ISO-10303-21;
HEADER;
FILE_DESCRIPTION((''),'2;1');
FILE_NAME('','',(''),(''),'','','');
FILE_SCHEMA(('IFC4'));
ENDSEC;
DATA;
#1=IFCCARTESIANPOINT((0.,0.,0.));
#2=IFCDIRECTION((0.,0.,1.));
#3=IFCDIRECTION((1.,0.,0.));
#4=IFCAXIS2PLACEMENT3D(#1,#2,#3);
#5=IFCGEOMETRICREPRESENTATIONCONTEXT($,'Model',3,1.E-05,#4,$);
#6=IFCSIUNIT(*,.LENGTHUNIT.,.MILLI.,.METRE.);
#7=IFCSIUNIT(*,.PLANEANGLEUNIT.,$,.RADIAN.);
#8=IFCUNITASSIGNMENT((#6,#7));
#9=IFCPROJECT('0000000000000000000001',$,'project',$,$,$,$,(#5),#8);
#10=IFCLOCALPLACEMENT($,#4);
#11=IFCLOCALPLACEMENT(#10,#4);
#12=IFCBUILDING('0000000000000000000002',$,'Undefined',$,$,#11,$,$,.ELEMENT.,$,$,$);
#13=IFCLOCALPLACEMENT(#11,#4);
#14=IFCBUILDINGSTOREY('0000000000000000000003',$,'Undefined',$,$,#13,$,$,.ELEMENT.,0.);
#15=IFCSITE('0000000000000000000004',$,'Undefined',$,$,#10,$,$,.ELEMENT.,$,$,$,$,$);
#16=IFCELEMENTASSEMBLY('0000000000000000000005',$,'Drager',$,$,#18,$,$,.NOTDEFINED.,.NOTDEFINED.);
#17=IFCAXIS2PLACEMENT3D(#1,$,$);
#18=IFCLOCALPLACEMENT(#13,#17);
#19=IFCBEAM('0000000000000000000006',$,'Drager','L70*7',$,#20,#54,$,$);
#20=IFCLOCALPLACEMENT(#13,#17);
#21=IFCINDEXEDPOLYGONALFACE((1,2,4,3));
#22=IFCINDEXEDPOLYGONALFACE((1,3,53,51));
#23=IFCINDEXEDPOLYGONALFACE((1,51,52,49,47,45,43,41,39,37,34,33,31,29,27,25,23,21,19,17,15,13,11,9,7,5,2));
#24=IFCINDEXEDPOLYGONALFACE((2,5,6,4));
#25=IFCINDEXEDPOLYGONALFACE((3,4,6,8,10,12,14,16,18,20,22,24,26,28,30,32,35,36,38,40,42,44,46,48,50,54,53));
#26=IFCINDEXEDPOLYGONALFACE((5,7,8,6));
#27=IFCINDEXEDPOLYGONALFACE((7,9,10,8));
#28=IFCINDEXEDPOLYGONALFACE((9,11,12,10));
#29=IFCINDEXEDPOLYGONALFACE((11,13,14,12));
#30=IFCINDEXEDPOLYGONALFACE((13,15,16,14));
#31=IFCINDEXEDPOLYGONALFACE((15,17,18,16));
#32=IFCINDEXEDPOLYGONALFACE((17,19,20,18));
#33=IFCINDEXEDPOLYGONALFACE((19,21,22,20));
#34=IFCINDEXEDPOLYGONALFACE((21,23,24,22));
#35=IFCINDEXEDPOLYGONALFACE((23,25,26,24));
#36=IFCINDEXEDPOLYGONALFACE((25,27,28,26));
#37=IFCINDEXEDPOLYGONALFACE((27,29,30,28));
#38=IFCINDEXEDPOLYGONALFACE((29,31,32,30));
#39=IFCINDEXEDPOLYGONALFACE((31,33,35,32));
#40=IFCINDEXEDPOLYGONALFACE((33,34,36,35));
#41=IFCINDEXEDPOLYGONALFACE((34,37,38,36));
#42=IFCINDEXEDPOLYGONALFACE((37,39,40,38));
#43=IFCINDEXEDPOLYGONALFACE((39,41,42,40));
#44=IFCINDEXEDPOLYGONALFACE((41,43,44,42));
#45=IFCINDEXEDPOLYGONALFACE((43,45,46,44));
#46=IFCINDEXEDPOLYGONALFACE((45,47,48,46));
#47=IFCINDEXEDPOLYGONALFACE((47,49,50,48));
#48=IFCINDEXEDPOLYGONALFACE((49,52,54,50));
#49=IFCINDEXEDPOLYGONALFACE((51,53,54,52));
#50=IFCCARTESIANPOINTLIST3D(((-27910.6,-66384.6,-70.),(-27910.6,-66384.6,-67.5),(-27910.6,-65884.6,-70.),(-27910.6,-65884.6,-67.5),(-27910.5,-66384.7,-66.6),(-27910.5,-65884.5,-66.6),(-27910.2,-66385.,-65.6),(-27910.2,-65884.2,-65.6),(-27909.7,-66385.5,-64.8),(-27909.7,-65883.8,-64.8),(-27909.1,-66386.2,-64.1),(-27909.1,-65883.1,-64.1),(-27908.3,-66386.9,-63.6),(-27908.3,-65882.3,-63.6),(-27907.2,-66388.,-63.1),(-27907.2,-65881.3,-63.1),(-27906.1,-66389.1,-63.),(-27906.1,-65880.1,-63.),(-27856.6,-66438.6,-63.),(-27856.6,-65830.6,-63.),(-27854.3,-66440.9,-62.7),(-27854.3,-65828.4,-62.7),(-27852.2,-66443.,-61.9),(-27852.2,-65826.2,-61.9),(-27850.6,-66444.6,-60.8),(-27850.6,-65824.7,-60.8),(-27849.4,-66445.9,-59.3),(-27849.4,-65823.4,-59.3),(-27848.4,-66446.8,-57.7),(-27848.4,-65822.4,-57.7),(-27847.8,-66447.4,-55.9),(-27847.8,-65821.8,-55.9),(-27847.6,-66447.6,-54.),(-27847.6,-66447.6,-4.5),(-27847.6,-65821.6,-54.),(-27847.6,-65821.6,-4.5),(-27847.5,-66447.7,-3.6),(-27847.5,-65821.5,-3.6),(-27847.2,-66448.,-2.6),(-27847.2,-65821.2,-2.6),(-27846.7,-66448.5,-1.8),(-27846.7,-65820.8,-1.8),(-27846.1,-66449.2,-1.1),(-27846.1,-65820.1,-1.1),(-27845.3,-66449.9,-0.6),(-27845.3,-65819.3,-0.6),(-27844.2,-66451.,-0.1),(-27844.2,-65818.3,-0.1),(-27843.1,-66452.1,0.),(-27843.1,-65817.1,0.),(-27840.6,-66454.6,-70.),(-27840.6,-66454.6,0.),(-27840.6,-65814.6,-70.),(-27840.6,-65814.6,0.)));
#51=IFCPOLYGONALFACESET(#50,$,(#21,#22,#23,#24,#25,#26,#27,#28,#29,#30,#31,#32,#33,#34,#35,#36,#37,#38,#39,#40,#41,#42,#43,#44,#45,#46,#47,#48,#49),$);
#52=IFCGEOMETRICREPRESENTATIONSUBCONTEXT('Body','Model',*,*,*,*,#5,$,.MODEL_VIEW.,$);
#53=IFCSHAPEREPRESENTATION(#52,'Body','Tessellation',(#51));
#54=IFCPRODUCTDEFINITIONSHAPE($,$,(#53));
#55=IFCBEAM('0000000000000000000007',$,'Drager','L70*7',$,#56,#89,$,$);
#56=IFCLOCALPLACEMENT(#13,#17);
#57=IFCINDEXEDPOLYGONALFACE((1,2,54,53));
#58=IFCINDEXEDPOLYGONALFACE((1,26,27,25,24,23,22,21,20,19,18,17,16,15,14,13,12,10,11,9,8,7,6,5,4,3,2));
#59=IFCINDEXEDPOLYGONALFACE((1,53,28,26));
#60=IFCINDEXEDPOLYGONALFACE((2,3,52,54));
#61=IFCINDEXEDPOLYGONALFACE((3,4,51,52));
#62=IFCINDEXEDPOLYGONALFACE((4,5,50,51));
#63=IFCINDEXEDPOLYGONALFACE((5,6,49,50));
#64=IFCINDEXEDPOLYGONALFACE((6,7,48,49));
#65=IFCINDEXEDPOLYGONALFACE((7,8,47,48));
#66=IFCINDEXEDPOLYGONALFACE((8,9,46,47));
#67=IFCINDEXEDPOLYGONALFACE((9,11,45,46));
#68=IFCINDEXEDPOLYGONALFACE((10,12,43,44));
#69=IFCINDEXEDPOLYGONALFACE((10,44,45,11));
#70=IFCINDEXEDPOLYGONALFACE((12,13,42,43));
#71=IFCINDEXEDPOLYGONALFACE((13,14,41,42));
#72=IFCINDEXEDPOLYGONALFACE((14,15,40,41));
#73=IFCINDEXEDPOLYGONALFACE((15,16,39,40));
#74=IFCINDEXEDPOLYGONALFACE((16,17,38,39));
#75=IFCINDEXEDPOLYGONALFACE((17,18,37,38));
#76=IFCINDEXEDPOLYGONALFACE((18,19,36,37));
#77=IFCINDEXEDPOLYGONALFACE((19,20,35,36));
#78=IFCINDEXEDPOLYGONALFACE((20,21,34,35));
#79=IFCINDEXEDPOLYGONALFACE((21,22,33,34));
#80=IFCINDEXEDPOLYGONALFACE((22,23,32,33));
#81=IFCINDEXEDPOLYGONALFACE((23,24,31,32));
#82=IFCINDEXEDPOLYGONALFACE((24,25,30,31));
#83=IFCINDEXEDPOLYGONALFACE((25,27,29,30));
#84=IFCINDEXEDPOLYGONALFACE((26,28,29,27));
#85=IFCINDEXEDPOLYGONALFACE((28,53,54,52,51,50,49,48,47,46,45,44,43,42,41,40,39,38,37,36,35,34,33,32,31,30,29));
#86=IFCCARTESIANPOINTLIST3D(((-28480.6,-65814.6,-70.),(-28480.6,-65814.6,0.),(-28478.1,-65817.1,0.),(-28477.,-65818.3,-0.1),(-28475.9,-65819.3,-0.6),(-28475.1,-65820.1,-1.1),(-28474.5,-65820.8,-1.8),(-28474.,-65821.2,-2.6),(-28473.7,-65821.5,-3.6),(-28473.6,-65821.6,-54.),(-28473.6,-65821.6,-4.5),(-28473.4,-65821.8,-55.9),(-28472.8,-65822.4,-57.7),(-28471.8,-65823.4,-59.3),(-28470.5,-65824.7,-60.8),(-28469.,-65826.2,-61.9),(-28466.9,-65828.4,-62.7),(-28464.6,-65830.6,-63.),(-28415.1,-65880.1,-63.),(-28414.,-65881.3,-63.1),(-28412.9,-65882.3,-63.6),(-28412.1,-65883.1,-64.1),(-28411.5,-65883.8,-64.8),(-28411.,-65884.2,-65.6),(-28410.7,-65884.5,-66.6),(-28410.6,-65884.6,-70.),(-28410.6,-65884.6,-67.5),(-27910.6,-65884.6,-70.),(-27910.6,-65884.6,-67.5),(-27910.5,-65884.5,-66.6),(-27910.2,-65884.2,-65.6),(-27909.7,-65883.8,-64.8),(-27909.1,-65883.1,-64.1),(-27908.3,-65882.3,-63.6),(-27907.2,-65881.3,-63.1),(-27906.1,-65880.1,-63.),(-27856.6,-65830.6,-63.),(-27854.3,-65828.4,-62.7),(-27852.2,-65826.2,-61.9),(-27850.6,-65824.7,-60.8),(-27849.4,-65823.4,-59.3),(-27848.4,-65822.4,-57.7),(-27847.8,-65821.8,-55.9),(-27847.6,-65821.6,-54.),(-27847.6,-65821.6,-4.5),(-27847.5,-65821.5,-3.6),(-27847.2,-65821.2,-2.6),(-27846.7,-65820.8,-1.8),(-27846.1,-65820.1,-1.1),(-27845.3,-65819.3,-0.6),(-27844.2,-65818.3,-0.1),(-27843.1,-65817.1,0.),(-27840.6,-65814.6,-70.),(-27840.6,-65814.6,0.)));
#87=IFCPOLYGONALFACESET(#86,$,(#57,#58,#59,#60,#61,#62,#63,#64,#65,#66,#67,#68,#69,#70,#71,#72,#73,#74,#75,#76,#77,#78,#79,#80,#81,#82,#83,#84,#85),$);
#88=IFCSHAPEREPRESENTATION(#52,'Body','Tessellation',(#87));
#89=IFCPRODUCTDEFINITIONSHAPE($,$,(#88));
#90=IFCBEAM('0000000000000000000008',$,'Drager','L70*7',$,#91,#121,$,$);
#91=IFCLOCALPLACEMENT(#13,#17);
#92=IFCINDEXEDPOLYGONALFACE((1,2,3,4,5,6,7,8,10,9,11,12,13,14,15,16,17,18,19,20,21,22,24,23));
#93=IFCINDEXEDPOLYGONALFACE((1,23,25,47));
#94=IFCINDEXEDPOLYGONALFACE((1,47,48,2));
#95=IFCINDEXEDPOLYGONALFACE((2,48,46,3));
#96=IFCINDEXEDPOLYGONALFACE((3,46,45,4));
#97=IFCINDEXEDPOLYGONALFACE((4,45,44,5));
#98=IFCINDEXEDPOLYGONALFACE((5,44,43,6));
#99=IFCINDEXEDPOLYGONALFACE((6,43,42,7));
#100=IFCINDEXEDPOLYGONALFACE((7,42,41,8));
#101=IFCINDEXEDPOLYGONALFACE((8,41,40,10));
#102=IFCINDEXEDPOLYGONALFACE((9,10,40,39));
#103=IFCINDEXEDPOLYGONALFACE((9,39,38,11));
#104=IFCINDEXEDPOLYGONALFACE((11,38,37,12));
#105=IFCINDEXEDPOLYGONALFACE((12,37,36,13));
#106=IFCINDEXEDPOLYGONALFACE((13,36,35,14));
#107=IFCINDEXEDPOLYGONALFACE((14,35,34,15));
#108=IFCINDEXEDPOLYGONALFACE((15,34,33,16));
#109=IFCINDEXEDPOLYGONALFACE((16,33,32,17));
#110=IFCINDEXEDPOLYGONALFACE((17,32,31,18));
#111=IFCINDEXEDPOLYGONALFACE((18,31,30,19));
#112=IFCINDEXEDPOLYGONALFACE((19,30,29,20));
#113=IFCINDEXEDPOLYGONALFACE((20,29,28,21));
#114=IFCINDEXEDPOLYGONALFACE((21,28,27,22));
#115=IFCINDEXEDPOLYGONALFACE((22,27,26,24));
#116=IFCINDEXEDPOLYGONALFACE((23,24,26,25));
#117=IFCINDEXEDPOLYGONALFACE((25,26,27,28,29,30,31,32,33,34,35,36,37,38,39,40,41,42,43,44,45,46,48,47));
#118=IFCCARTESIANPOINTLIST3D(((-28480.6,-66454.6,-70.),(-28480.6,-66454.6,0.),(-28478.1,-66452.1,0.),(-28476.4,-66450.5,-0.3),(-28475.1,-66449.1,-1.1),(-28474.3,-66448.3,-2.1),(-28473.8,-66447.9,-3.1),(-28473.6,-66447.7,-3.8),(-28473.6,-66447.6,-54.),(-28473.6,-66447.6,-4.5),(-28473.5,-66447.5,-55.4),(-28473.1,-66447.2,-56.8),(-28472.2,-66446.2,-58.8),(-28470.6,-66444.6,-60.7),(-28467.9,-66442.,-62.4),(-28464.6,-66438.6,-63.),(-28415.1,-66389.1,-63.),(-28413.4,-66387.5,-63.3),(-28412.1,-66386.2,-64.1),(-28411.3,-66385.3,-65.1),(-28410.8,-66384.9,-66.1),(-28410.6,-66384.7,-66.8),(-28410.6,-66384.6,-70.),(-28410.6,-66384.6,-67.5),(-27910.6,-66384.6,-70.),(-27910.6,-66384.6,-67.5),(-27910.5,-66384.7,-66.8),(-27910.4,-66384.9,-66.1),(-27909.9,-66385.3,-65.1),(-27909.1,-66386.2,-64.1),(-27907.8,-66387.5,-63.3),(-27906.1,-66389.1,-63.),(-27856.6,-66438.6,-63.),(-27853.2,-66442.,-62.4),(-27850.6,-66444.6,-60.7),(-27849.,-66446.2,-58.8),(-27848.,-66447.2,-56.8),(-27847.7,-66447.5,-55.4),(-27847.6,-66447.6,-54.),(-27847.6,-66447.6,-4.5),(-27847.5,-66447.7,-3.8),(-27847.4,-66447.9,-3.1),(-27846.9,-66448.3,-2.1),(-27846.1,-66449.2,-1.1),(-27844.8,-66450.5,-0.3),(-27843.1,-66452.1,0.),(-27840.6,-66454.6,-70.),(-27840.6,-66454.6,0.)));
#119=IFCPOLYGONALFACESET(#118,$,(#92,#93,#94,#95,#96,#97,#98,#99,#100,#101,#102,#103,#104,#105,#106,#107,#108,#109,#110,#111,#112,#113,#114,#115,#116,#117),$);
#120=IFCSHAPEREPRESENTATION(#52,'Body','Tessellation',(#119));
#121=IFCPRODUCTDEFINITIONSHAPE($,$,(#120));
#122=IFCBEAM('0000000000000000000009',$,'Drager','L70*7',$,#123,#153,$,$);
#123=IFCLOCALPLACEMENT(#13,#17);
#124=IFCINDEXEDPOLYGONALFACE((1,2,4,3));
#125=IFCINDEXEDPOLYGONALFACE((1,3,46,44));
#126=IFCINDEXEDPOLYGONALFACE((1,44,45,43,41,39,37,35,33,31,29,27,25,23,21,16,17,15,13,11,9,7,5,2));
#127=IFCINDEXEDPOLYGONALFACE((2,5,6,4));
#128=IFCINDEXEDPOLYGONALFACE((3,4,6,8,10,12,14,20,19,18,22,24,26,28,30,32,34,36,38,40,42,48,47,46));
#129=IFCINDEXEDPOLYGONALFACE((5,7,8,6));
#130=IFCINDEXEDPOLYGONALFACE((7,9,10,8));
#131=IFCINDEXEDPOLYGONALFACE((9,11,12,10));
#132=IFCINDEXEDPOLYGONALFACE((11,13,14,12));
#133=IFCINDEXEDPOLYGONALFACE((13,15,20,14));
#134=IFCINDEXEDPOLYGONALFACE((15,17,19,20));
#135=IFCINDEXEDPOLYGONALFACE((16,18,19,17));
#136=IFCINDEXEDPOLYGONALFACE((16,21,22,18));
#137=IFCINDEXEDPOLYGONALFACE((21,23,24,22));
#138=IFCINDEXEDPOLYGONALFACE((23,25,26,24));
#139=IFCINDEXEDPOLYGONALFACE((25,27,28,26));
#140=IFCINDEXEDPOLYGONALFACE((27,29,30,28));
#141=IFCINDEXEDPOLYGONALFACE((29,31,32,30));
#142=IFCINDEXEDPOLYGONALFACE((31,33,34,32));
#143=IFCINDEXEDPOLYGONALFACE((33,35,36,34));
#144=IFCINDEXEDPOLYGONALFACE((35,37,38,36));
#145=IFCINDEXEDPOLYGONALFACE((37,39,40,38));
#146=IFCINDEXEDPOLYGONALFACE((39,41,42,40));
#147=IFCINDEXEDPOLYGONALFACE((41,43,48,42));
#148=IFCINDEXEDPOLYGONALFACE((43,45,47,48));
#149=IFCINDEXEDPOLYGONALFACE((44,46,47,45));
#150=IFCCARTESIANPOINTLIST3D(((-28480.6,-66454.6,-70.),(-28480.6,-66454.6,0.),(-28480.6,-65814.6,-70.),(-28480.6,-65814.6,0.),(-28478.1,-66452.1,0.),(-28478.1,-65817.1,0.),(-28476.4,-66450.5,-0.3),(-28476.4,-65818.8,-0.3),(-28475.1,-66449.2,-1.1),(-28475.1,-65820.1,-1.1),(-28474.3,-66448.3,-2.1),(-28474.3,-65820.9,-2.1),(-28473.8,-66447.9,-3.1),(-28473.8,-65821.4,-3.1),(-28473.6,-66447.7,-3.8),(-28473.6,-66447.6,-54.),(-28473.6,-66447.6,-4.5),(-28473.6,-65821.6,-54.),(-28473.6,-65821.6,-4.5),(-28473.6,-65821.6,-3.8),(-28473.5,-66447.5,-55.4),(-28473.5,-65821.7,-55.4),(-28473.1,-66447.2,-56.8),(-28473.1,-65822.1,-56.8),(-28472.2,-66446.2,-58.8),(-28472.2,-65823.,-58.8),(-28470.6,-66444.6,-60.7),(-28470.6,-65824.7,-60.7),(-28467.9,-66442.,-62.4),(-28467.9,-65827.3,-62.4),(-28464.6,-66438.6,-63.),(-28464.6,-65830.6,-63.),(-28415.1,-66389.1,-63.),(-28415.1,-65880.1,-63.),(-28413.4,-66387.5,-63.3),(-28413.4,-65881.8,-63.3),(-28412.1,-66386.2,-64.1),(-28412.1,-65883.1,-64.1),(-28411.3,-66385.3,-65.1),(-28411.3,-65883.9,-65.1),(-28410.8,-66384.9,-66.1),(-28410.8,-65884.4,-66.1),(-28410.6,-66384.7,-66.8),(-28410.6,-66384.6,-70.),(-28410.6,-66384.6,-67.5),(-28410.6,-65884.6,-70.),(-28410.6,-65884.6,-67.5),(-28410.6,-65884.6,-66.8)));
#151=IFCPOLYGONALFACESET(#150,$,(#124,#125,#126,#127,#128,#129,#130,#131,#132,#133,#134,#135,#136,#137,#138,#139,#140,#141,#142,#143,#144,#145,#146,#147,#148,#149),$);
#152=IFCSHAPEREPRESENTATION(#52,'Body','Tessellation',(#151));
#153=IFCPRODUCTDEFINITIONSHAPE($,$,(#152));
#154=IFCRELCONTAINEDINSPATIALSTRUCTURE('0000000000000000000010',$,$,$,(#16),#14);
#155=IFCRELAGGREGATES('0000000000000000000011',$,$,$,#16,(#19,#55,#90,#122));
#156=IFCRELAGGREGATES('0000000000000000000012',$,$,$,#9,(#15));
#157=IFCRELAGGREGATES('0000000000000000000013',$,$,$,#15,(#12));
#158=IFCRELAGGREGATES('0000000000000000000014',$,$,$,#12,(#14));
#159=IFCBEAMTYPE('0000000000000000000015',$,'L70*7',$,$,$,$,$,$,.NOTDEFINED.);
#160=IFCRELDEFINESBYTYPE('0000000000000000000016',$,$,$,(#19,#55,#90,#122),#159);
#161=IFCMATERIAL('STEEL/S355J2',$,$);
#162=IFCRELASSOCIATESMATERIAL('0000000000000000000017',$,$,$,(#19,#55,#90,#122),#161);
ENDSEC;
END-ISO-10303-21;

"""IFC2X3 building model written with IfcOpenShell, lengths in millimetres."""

from ifc_helpers import new_model, si_unit, frame, origin_with_axes, origin_2d_with_axis, place, context, subcontext, project, spatial, l_section, extrude, clip, halfspace, material, type_object, element, aggregate, save


model = new_model("IFC2X3")

# Units and contexts
model_context = context("Model", 3, precision=1e-05, world=origin_with_axes())
body_context = subcontext(model_context, "Body", "Model", "MODEL_VIEW")
ifc_project = project(units=[si_unit("LENGTHUNIT", "METRE", prefix="MILLI"), si_unit("PLANEANGLEUNIT", "RADIAN")], contexts=[model_context])

# Site, building, storey
site_placement = place(None, origin_with_axes())
site = spatial("IfcSite", under=ifc_project, at=site_placement, Name="Undefined", CompositionType="ELEMENT")
building_placement = place(site_placement, origin_with_axes())
building = spatial("IfcBuilding", under=site, at=building_placement, Name="Undefined", CompositionType="ELEMENT")
storey_placement = place(building_placement, origin_with_axes())
storey = spatial("IfcBuildingStorey", under=building, at=storey_placement, Name="Undefined", CompositionType="ELEMENT", Elevation=0.0)

# Shared definitions
ifc_material_1 = material(Name="STEEL/S355J2")
beam_type_1 = type_object("IfcBeamType", Name="L70*7", PredefinedType="NOTDEFINED")

# Element assembly, beams
assembly_1_placement = place(storey_placement, origin_with_axes())
assembly_1 = element("IfcElementAssembly", 1, at=assembly_1_placement, inside=storey, Name="Drager", AssemblyPlace="NOTDEFINED", PredefinedType="NOTDEFINED")
beam_1_placement = place(assembly_1_placement, frame((-27875.6, -65884.6, -35.0), z_axis=(0.0, 0.0, 1.0), x_axis=(0.000002, -1.0, 0.0)))
beam_1 = element("IfcBeam", 2, at=beam_1_placement, type_object=beam_type_1, material=ifc_material_1, Name="Drager", Description="L70*7", context=body_context, shape_type="Clipping", body=[
    clip(clip(extrude(l_section(Depth=70.0, Width=70.0, Thickness=7.0, FilletRadius=9.0, EdgeRadius=4.5, at=origin_2d_with_axis()), frame((605.7, 0.0, 0.0), z_axis=(-1.0, 0.0, 0.0), x_axis=(0.0, -1.0, 0.0)), (0.0, 0.0, 1.0), 711.4), halfspace(frame((500.0, -35.0, 35.0), z_axis=(-0.707107, 0.707107, 0.0), x_axis=(0.707107, 0.707107, 0.0)), True)), halfspace(frame((0.0, -35.0, 35.0), z_axis=(-0.707107, -0.707107, 0.0), x_axis=(-0.707107, 0.707107, 0.0)), False)),
])
beam_2_placement = place(assembly_1_placement, frame((-28410.6, -65849.6, -35.0), z_axis=(0.0, 0.0, 1.0), x_axis=(1.0, 0.000003, 0.0)))
beam_2 = element("IfcBeam", 3, at=beam_2_placement, type_object=beam_type_1, material=ifc_material_1, Name="Drager", Description="L70*7", context=body_context, shape_type="Clipping", body=[
    clip(clip(extrude(l_section(Depth=70.0, Width=70.0, Thickness=7.0, FilletRadius=9.0, EdgeRadius=4.5, at=origin_2d_with_axis()), frame((605.7, 0.0, 0.0), z_axis=(-1.0, 0.0, 0.0), x_axis=(0.0, -1.0, 0.0)), (0.0, 0.0, 1.0), 711.4), halfspace(frame((500.0, -35.0, 35.0), z_axis=(-0.707107, 0.707107, 0.0), x_axis=(0.707107, 0.707107, 0.0)), True)), halfspace(frame((0.0, -35.0, 35.0), z_axis=(-0.707107, -0.707107, 0.0), x_axis=(-0.707107, 0.707107, 0.0)), False)),
])
beam_3_placement = place(assembly_1_placement, frame((-27910.6, -66419.6, -35.0), z_axis=(0.0, 0.0, 1.0), x_axis=(-1.0, 0.0, 0.0)))
beam_3 = element("IfcBeam", 4, at=beam_3_placement, type_object=beam_type_1, material=ifc_material_1, Name="Drager", Description="L70*7", context=body_context, shape_type="Clipping", body=[
    clip(clip(extrude(l_section(Depth=70.0, Width=70.0, Thickness=7.0, FilletRadius=9.0, EdgeRadius=4.5, at=origin_2d_with_axis()), frame((605.7, 0.0, 0.0), z_axis=(-1.0, 0.0, 0.0), x_axis=(0.0, -1.0, 0.0)), (0.0, 0.0, 1.0), 711.4), halfspace(frame((500.0, -35.0, 35.0), z_axis=(0.707107, -0.707107, 0.0), x_axis=(0.0, 0.0, 1.0)), False)), halfspace(frame((0.0, -35.0, 35.0), z_axis=(0.707107, 0.707107, 0.0), x_axis=(0.0, 0.0, 1.0)), True)),
])
beam_4_placement = place(assembly_1_placement, frame((-28445.6, -66384.6, -35.0), z_axis=(0.0, 0.0, 1.0), x_axis=(0.0, 1.0, 0.0)))
beam_4 = element("IfcBeam", 5, at=beam_4_placement, type_object=beam_type_1, material=ifc_material_1, Name="Drager", Description="L70*7", context=body_context, shape_type="Clipping", body=[
    clip(clip(extrude(l_section(Depth=70.0, Width=70.0, Thickness=7.0, FilletRadius=9.0, EdgeRadius=4.5, at=origin_2d_with_axis()), frame((605.7, 0.0, 0.0), z_axis=(-1.0, 0.0, 0.0), x_axis=(0.0, -1.0, 0.0)), (0.0, 0.0, 1.0), 711.4), halfspace(frame((500.0, -35.0, 35.0), z_axis=(0.707107, -0.707107, 0.0), x_axis=(0.0, 0.0, 1.0)), False)), halfspace(frame((0.0, -35.0, 35.0), z_axis=(0.707107, 0.707107, 0.0), x_axis=(0.0, 0.0, 1.0)), True)),
])
aggregate(assembly_1, [beam_1, beam_2, beam_3, beam_4])

save(model, "model.ifc")
